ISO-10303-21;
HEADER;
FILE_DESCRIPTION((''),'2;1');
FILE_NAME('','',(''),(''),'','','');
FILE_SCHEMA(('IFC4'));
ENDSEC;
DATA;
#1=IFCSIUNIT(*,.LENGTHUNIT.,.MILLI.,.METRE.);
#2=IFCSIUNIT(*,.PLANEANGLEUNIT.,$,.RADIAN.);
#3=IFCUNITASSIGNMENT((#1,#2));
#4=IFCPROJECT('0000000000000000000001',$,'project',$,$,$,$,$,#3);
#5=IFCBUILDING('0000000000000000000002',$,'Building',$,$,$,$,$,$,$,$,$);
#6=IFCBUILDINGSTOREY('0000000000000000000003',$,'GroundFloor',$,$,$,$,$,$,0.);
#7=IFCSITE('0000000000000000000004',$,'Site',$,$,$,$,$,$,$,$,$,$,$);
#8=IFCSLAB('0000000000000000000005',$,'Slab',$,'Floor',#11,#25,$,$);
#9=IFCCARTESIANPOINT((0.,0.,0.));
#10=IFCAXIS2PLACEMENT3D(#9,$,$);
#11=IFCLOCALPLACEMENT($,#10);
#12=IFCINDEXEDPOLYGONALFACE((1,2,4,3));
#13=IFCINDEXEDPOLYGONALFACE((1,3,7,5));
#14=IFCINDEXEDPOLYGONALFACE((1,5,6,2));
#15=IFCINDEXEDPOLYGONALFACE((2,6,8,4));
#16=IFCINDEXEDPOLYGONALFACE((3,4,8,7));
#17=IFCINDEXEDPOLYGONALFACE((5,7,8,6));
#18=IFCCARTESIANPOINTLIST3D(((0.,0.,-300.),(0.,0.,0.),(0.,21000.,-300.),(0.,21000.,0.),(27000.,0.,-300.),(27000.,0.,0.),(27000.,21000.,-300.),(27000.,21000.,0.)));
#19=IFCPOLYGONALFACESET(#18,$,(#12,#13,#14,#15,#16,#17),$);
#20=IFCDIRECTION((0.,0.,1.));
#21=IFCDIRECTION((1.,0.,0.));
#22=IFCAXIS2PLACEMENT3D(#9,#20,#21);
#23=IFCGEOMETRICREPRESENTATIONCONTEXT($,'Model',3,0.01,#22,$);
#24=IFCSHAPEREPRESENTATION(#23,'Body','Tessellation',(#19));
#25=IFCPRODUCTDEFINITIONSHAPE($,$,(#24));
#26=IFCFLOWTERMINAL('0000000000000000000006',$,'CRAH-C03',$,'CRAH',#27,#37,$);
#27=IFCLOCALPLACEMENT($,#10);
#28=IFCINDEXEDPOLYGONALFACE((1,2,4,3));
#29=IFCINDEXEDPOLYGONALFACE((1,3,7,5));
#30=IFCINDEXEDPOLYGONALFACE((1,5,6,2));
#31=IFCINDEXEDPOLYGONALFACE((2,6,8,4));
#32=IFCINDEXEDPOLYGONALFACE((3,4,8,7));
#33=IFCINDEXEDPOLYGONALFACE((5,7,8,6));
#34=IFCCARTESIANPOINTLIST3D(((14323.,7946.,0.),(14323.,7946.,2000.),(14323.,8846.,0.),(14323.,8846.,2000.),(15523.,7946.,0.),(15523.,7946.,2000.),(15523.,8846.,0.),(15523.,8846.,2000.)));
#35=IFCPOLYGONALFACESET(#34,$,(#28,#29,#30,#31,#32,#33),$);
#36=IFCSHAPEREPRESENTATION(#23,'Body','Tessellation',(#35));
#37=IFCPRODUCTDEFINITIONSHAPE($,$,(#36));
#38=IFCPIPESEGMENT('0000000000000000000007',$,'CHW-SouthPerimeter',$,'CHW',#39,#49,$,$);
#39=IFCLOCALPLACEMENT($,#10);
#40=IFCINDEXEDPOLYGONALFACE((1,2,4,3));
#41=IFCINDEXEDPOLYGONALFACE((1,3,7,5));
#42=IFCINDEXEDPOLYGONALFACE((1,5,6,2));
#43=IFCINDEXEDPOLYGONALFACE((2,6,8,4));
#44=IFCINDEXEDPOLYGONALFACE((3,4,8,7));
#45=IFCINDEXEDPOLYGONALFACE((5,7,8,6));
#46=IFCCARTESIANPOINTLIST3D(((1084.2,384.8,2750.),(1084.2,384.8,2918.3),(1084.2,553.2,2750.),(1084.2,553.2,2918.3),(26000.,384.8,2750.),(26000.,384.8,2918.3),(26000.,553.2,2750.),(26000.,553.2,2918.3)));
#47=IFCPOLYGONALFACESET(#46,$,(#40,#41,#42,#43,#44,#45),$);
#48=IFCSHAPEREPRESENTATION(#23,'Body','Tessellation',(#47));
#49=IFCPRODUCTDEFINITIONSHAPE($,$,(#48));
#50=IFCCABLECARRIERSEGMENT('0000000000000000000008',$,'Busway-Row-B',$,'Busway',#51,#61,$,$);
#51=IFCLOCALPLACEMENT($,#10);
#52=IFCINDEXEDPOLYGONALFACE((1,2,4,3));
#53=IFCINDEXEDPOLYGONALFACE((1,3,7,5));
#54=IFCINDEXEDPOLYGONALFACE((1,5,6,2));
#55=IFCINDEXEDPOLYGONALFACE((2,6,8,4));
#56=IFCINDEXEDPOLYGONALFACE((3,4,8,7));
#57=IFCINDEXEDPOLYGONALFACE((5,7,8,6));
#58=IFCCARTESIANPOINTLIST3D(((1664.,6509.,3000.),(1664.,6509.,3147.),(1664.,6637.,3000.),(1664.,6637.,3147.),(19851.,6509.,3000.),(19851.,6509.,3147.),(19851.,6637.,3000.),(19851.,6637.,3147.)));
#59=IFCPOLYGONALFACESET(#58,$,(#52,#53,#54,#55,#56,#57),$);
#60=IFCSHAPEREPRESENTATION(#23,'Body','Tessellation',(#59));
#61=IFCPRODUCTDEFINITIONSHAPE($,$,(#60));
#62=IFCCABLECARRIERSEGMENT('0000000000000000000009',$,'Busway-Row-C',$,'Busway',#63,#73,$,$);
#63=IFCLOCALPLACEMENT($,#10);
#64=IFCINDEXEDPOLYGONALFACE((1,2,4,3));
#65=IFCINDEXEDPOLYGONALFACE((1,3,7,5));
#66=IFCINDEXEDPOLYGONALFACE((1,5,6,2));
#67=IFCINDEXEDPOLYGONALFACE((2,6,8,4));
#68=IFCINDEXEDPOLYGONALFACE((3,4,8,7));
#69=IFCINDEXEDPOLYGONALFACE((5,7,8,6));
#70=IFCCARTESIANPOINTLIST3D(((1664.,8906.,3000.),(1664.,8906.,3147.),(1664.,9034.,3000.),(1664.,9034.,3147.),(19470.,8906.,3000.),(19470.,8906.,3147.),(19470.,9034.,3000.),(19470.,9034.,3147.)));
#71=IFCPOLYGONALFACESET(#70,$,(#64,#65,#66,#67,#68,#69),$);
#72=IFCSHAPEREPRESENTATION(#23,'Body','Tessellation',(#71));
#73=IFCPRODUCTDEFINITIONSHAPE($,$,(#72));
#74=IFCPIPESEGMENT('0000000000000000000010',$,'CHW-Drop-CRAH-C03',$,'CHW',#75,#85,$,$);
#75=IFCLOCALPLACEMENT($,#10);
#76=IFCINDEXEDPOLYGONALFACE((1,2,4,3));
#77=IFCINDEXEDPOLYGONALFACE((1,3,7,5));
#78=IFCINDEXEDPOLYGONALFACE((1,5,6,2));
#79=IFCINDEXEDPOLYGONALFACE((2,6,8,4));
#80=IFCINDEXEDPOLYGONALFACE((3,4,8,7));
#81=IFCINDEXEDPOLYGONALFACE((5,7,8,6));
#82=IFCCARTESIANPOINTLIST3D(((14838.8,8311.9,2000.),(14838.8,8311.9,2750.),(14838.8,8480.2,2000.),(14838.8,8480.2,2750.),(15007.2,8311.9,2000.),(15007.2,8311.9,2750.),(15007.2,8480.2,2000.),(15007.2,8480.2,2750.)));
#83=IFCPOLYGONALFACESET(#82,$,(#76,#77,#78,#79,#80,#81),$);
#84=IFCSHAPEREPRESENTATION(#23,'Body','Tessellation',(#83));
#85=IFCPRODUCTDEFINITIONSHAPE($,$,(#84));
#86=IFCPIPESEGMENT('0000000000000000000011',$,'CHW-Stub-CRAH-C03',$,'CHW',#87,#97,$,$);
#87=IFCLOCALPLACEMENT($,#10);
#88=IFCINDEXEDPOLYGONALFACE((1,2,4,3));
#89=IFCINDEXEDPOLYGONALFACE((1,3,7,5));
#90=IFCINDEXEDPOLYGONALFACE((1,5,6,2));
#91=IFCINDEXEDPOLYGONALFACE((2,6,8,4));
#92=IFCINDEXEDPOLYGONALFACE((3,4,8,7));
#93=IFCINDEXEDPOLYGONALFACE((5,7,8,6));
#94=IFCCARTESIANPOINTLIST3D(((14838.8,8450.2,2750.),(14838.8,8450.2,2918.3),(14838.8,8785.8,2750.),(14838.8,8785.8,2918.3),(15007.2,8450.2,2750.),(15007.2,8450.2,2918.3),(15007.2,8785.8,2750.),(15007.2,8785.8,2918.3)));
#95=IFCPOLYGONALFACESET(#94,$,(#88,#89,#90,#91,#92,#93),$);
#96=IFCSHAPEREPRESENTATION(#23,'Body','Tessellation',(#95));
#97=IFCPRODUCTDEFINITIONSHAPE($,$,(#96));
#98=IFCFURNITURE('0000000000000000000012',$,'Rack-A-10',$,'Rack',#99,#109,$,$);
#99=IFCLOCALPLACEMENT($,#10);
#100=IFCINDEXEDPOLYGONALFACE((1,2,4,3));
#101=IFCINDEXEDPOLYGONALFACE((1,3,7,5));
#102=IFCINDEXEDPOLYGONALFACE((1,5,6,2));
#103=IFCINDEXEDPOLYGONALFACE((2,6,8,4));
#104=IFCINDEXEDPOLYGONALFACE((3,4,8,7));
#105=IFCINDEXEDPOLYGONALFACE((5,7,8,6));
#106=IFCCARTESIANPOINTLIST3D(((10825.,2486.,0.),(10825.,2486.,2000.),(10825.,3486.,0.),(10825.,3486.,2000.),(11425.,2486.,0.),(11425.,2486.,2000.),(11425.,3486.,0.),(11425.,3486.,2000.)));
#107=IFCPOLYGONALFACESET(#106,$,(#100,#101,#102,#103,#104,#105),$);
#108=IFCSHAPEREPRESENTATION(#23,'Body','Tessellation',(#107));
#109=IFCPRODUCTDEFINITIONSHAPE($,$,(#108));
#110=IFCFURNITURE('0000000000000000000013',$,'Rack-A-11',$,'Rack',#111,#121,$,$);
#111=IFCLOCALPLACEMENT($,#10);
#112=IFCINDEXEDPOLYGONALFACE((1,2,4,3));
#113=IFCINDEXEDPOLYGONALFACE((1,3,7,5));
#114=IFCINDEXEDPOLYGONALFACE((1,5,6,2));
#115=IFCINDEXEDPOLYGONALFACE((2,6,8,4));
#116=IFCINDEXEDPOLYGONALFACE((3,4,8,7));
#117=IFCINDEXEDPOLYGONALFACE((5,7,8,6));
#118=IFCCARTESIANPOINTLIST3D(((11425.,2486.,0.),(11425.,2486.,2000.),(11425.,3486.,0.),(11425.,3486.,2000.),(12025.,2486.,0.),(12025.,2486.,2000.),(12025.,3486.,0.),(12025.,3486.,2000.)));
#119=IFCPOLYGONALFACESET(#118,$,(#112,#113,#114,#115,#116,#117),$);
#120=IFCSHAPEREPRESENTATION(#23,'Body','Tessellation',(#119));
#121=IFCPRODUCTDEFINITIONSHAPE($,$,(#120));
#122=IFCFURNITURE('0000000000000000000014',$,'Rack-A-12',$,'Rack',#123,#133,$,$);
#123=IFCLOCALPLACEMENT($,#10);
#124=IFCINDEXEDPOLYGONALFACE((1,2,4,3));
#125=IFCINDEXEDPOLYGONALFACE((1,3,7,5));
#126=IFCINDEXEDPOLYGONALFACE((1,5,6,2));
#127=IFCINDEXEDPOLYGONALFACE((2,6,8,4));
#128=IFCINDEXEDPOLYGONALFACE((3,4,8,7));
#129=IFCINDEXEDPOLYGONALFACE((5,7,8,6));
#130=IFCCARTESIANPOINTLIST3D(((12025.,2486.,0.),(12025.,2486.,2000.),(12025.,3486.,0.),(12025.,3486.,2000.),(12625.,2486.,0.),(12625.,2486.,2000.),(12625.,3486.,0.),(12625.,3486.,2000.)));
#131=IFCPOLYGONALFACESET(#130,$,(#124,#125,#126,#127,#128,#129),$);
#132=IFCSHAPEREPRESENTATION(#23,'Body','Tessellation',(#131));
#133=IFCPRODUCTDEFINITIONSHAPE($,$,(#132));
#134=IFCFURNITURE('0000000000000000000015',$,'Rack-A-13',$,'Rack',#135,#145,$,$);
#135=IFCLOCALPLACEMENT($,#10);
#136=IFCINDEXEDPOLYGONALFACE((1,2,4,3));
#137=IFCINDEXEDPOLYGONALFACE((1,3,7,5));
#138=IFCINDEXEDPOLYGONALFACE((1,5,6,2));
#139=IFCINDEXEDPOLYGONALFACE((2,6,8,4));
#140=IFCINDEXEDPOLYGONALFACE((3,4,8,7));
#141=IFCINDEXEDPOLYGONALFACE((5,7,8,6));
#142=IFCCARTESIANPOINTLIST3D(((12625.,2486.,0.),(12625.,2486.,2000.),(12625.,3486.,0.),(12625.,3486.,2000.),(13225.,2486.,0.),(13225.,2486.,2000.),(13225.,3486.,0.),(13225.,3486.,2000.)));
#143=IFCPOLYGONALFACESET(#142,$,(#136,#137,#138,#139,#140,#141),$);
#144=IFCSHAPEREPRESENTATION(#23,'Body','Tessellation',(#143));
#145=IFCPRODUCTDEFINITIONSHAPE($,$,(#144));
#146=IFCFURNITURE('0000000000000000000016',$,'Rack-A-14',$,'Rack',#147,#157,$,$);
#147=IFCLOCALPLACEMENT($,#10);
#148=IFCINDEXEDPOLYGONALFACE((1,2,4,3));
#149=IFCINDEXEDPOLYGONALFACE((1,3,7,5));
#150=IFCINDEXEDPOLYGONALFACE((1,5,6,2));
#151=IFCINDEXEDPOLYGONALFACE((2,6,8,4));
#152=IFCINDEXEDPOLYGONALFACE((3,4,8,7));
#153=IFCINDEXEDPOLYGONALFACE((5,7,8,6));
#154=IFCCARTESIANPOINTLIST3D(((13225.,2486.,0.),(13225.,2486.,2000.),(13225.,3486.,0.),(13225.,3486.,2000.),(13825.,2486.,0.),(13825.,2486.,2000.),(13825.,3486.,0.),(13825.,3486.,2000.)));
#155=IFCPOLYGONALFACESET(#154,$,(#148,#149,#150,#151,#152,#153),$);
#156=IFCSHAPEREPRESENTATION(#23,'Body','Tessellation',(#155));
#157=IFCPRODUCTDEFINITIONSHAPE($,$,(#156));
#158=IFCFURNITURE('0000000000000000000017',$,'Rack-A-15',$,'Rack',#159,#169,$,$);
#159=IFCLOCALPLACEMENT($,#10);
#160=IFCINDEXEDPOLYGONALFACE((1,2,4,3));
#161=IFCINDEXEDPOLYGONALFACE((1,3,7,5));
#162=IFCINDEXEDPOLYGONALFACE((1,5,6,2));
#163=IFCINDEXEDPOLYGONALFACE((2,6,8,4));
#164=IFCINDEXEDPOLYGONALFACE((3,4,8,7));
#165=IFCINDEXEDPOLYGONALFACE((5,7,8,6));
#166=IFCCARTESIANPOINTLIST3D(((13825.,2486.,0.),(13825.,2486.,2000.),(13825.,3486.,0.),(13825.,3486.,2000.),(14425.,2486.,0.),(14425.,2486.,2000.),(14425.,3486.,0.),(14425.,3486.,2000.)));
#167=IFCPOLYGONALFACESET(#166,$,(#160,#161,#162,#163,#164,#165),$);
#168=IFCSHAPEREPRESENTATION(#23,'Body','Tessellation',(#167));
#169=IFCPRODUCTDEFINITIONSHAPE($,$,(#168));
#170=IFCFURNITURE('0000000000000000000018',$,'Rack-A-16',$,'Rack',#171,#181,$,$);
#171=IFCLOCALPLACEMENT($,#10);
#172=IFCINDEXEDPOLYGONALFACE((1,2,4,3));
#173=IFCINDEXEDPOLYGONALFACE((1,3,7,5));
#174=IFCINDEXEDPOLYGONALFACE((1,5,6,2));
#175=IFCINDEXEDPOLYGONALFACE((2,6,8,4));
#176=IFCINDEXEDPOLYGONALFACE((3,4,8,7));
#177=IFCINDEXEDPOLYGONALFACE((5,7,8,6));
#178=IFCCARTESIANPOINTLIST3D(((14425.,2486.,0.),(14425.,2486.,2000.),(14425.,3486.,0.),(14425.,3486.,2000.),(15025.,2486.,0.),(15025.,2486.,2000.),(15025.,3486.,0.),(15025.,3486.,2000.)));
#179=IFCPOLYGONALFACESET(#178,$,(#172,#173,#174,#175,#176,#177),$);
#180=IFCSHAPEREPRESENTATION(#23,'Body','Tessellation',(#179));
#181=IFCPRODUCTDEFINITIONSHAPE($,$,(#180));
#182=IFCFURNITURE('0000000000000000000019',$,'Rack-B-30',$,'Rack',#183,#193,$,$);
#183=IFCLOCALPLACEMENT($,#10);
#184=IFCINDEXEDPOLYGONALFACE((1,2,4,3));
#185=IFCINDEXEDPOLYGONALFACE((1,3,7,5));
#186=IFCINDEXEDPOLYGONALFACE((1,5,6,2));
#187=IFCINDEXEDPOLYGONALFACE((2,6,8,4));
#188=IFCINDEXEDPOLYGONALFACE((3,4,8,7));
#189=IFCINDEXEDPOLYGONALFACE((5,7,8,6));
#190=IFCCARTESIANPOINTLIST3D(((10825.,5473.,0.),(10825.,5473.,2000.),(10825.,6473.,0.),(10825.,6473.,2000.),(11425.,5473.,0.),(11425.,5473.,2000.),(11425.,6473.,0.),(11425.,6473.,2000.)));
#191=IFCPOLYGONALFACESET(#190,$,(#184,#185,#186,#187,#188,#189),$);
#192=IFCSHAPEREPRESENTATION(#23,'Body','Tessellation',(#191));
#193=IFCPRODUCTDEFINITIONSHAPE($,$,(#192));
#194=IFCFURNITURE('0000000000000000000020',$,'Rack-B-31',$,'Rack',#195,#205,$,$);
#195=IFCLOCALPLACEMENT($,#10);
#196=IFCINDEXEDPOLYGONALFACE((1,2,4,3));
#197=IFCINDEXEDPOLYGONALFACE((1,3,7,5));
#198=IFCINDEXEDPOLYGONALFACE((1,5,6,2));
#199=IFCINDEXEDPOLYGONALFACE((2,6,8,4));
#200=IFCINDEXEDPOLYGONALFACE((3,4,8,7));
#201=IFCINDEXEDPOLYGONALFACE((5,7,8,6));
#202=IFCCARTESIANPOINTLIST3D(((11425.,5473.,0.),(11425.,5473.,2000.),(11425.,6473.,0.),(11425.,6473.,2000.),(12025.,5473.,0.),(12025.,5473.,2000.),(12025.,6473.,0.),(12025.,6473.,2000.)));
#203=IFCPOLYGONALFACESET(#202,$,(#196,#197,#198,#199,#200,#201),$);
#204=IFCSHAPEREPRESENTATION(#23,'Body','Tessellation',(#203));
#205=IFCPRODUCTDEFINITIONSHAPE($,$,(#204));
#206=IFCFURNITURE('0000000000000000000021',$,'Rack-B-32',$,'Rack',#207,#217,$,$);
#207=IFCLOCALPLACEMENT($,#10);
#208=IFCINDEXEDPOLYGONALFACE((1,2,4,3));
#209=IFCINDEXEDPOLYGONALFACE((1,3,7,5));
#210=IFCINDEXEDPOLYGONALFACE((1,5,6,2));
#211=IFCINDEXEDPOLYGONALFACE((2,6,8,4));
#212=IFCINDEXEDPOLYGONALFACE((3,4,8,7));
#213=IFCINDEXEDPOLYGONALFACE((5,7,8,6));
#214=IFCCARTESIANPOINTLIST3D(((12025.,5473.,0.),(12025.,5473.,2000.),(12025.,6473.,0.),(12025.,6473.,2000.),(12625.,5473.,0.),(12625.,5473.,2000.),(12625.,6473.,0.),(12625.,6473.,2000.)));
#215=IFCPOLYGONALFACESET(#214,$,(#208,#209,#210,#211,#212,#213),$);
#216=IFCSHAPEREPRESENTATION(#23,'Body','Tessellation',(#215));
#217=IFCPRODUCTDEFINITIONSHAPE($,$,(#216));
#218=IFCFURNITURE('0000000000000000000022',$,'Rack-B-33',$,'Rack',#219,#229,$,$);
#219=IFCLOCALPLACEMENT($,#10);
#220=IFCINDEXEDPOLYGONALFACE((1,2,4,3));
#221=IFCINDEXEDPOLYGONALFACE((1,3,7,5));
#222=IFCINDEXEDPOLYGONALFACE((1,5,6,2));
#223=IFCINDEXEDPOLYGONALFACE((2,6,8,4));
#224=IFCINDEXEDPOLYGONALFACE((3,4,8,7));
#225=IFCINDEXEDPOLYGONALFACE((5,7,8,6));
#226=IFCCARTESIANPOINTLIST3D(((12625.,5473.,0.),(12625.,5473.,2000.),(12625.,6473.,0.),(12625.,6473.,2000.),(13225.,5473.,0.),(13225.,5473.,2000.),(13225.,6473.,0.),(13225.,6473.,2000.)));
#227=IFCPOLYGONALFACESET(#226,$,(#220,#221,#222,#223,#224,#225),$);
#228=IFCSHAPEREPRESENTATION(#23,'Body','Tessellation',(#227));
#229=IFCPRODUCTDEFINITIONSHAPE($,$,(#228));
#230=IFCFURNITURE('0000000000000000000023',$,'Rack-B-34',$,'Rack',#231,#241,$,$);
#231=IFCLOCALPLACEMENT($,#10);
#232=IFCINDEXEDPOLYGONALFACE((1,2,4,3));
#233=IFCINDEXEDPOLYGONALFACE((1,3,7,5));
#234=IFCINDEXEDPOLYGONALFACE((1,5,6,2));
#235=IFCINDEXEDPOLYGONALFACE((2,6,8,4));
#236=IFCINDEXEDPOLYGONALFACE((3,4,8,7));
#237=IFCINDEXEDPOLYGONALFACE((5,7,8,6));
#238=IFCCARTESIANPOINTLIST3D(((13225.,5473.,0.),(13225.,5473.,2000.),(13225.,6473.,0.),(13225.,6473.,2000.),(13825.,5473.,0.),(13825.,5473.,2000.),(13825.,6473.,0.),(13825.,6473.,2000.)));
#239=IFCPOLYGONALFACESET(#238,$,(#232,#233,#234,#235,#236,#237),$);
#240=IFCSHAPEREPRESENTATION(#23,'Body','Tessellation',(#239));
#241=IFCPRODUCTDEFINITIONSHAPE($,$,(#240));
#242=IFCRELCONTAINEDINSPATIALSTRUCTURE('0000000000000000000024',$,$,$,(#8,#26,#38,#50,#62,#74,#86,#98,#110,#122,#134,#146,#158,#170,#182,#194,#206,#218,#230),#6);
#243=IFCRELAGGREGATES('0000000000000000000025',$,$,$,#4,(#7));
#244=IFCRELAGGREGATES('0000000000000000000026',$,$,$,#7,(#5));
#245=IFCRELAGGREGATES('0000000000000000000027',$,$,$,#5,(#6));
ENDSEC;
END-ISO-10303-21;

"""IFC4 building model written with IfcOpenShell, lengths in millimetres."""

from ifc_helpers import new_model, si_unit, frame, origin, origin_with_axes, origin_2d, place, context, project, spatial, rectangle, extrude, element, save


model = new_model("IFC4")

# Units and contexts
model_context = context("Model", 3, precision=0.01, world=origin_with_axes())
ifc_project = project(units=[si_unit("LENGTHUNIT", "METRE", prefix="MILLI"), si_unit("PLANEANGLEUNIT", "RADIAN")])

# Site, building, storey
site = spatial("IfcSite", under=ifc_project, Name="Site")
building = spatial("IfcBuilding", under=site, Name="Building")
storey = spatial("IfcBuildingStorey", under=building, Name="GroundFloor", Elevation=0.0)

# Slab
slab_placement = place(None, frame((13500.0, 10500.0, -300.0), z_axis=(0.0, 0.0, 1.0), x_axis=(1.0, 0.0, 0.0)))
element("IfcSlab", 1, at=slab_placement, inside=storey, Name="Slab", ObjectType="Floor", context=model_context, shape_type="SweptSolid", body=[
    extrude(rectangle(XDim=27000.0, YDim=21000.0, at=origin_2d()), origin(), (0.0, 0.0, 1.0), 300.0),
])

# Flow terminal
flow_terminal_placement = place(None, frame((14923.0, 8396.0, 0.0), z_axis=(0.0, 0.0, 1.0), x_axis=(1.0, 0.0, 0.0)))
element("IfcFlowTerminal", 2, at=flow_terminal_placement, inside=storey, Name="CRAH-C03", ObjectType="CRAH", context=model_context, shape_type="SweptSolid", body=[
    extrude(rectangle(XDim=1200.0, YDim=900.0, at=origin_2d()), origin(), (0.0, 0.0, 1.0), 2000.0),
])

# Pipe segment
pipe_segment_1_placement = place(None, frame((13542.1, 469.0, 2750.0), z_axis=(0.0, 0.0, 1.0), x_axis=(1.0, 0.0, 0.0)))
element("IfcPipeSegment", 3, at=pipe_segment_1_placement, inside=storey, Name="CHW-SouthPerimeter", ObjectType="CHW", context=model_context, shape_type="SweptSolid", body=[
    extrude(rectangle(XDim=24915.8, YDim=168.3, at=origin_2d()), origin(), (0.0, 0.0, 1.0), 168.3),
])

# Cable carrier segments
cable_carrier_segment_1_placement = place(None, frame((10757.5, 6573.0, 3000.0), z_axis=(0.0, 0.0, 1.0), x_axis=(1.0, 0.0, 0.0)))
element("IfcCableCarrierSegment", 4, at=cable_carrier_segment_1_placement, inside=storey, Name="Busway-Row-B", ObjectType="Busway", context=model_context, shape_type="SweptSolid", body=[
    extrude(rectangle(XDim=18187.0, YDim=128.0, at=origin_2d()), origin(), (0.0, 0.0, 1.0), 147.0),
])
cable_carrier_segment_2_placement = place(None, frame((10567.0, 8970.0, 3000.0), z_axis=(0.0, 0.0, 1.0), x_axis=(1.0, 0.0, 0.0)))
element("IfcCableCarrierSegment", 5, at=cable_carrier_segment_2_placement, inside=storey, Name="Busway-Row-C", ObjectType="Busway", context=model_context, shape_type="SweptSolid", body=[
    extrude(rectangle(XDim=17806.0, YDim=128.0, at=origin_2d()), origin(), (0.0, 0.0, 1.0), 147.0),
])

# Pipe segments
pipe_segment_2_placement = place(None, frame((14923.0, 8396.0, 2000.0), z_axis=(0.0, 0.0, 1.0), x_axis=(1.0, 0.0, 0.0)))
element("IfcPipeSegment", 6, at=pipe_segment_2_placement, inside=storey, Name="CHW-Drop-CRAH-C03", ObjectType="CHW", context=model_context, shape_type="SweptSolid", body=[
    extrude(rectangle(XDim=168.3, YDim=168.3, at=origin_2d()), origin(), (0.0, 0.0, 1.0), 750.0),
])
pipe_segment_3_placement = place(None, frame((14923.0, 8618.0, 2750.0), z_axis=(0.0, 0.0, 1.0), x_axis=(1.0, 0.0, 0.0)))
element("IfcPipeSegment", 7, at=pipe_segment_3_placement, inside=storey, Name="CHW-Stub-CRAH-C03", ObjectType="CHW", context=model_context, shape_type="SweptSolid", body=[
    extrude(rectangle(XDim=168.3, YDim=335.7, at=origin_2d()), origin(), (0.0, 0.0, 1.0), 168.3),
])

# Furniture
for number, where, z_axis, x_axis, name in (
    (8, (11125.0, 2986.0, 0.0), (0.0, 0.0, 1.0), (1.0, 0.0, 0.0), "Rack-A-10"),
    (9, (11725.0, 2986.0, 0.0), (0.0, 0.0, 1.0), (1.0, 0.0, 0.0), "Rack-A-11"),
    (10, (12325.0, 2986.0, 0.0), (0.0, 0.0, 1.0), (1.0, 0.0, 0.0), "Rack-A-12"),
    (11, (12925.0, 2986.0, 0.0), (0.0, 0.0, 1.0), (1.0, 0.0, 0.0), "Rack-A-13"),
    (12, (13525.0, 2986.0, 0.0), (0.0, 0.0, 1.0), (1.0, 0.0, 0.0), "Rack-A-14"),
    (13, (14125.0, 2986.0, 0.0), (0.0, 0.0, 1.0), (1.0, 0.0, 0.0), "Rack-A-15"),
    (14, (14725.0, 2986.0, 0.0), (0.0, 0.0, 1.0), (1.0, 0.0, 0.0), "Rack-A-16"),
    (15, (11125.0, 5973.0, 0.0), (0.0, 0.0, 1.0), (1.0, 0.0, 0.0), "Rack-B-30"),
    (16, (11725.0, 5973.0, 0.0), (0.0, 0.0, 1.0), (1.0, 0.0, 0.0), "Rack-B-31"),
    (17, (12325.0, 5973.0, 0.0), (0.0, 0.0, 1.0), (1.0, 0.0, 0.0), "Rack-B-32"),
    (18, (12925.0, 5973.0, 0.0), (0.0, 0.0, 1.0), (1.0, 0.0, 0.0), "Rack-B-33"),
    (19, (13525.0, 5973.0, 0.0), (0.0, 0.0, 1.0), (1.0, 0.0, 0.0), "Rack-B-34"),
):
    element("IfcFurniture", number, at=place(None, frame(where, z_axis=z_axis, x_axis=x_axis)), inside=storey, Name=name, ObjectType="Rack", context=model_context, shape_type="SweptSolid", body=[
        extrude(rectangle(XDim=600.0, YDim=1000.0, at=origin_2d()), origin(), (0.0, 0.0, 1.0), 2000.0),
    ])

save(model, "model.ifc")
